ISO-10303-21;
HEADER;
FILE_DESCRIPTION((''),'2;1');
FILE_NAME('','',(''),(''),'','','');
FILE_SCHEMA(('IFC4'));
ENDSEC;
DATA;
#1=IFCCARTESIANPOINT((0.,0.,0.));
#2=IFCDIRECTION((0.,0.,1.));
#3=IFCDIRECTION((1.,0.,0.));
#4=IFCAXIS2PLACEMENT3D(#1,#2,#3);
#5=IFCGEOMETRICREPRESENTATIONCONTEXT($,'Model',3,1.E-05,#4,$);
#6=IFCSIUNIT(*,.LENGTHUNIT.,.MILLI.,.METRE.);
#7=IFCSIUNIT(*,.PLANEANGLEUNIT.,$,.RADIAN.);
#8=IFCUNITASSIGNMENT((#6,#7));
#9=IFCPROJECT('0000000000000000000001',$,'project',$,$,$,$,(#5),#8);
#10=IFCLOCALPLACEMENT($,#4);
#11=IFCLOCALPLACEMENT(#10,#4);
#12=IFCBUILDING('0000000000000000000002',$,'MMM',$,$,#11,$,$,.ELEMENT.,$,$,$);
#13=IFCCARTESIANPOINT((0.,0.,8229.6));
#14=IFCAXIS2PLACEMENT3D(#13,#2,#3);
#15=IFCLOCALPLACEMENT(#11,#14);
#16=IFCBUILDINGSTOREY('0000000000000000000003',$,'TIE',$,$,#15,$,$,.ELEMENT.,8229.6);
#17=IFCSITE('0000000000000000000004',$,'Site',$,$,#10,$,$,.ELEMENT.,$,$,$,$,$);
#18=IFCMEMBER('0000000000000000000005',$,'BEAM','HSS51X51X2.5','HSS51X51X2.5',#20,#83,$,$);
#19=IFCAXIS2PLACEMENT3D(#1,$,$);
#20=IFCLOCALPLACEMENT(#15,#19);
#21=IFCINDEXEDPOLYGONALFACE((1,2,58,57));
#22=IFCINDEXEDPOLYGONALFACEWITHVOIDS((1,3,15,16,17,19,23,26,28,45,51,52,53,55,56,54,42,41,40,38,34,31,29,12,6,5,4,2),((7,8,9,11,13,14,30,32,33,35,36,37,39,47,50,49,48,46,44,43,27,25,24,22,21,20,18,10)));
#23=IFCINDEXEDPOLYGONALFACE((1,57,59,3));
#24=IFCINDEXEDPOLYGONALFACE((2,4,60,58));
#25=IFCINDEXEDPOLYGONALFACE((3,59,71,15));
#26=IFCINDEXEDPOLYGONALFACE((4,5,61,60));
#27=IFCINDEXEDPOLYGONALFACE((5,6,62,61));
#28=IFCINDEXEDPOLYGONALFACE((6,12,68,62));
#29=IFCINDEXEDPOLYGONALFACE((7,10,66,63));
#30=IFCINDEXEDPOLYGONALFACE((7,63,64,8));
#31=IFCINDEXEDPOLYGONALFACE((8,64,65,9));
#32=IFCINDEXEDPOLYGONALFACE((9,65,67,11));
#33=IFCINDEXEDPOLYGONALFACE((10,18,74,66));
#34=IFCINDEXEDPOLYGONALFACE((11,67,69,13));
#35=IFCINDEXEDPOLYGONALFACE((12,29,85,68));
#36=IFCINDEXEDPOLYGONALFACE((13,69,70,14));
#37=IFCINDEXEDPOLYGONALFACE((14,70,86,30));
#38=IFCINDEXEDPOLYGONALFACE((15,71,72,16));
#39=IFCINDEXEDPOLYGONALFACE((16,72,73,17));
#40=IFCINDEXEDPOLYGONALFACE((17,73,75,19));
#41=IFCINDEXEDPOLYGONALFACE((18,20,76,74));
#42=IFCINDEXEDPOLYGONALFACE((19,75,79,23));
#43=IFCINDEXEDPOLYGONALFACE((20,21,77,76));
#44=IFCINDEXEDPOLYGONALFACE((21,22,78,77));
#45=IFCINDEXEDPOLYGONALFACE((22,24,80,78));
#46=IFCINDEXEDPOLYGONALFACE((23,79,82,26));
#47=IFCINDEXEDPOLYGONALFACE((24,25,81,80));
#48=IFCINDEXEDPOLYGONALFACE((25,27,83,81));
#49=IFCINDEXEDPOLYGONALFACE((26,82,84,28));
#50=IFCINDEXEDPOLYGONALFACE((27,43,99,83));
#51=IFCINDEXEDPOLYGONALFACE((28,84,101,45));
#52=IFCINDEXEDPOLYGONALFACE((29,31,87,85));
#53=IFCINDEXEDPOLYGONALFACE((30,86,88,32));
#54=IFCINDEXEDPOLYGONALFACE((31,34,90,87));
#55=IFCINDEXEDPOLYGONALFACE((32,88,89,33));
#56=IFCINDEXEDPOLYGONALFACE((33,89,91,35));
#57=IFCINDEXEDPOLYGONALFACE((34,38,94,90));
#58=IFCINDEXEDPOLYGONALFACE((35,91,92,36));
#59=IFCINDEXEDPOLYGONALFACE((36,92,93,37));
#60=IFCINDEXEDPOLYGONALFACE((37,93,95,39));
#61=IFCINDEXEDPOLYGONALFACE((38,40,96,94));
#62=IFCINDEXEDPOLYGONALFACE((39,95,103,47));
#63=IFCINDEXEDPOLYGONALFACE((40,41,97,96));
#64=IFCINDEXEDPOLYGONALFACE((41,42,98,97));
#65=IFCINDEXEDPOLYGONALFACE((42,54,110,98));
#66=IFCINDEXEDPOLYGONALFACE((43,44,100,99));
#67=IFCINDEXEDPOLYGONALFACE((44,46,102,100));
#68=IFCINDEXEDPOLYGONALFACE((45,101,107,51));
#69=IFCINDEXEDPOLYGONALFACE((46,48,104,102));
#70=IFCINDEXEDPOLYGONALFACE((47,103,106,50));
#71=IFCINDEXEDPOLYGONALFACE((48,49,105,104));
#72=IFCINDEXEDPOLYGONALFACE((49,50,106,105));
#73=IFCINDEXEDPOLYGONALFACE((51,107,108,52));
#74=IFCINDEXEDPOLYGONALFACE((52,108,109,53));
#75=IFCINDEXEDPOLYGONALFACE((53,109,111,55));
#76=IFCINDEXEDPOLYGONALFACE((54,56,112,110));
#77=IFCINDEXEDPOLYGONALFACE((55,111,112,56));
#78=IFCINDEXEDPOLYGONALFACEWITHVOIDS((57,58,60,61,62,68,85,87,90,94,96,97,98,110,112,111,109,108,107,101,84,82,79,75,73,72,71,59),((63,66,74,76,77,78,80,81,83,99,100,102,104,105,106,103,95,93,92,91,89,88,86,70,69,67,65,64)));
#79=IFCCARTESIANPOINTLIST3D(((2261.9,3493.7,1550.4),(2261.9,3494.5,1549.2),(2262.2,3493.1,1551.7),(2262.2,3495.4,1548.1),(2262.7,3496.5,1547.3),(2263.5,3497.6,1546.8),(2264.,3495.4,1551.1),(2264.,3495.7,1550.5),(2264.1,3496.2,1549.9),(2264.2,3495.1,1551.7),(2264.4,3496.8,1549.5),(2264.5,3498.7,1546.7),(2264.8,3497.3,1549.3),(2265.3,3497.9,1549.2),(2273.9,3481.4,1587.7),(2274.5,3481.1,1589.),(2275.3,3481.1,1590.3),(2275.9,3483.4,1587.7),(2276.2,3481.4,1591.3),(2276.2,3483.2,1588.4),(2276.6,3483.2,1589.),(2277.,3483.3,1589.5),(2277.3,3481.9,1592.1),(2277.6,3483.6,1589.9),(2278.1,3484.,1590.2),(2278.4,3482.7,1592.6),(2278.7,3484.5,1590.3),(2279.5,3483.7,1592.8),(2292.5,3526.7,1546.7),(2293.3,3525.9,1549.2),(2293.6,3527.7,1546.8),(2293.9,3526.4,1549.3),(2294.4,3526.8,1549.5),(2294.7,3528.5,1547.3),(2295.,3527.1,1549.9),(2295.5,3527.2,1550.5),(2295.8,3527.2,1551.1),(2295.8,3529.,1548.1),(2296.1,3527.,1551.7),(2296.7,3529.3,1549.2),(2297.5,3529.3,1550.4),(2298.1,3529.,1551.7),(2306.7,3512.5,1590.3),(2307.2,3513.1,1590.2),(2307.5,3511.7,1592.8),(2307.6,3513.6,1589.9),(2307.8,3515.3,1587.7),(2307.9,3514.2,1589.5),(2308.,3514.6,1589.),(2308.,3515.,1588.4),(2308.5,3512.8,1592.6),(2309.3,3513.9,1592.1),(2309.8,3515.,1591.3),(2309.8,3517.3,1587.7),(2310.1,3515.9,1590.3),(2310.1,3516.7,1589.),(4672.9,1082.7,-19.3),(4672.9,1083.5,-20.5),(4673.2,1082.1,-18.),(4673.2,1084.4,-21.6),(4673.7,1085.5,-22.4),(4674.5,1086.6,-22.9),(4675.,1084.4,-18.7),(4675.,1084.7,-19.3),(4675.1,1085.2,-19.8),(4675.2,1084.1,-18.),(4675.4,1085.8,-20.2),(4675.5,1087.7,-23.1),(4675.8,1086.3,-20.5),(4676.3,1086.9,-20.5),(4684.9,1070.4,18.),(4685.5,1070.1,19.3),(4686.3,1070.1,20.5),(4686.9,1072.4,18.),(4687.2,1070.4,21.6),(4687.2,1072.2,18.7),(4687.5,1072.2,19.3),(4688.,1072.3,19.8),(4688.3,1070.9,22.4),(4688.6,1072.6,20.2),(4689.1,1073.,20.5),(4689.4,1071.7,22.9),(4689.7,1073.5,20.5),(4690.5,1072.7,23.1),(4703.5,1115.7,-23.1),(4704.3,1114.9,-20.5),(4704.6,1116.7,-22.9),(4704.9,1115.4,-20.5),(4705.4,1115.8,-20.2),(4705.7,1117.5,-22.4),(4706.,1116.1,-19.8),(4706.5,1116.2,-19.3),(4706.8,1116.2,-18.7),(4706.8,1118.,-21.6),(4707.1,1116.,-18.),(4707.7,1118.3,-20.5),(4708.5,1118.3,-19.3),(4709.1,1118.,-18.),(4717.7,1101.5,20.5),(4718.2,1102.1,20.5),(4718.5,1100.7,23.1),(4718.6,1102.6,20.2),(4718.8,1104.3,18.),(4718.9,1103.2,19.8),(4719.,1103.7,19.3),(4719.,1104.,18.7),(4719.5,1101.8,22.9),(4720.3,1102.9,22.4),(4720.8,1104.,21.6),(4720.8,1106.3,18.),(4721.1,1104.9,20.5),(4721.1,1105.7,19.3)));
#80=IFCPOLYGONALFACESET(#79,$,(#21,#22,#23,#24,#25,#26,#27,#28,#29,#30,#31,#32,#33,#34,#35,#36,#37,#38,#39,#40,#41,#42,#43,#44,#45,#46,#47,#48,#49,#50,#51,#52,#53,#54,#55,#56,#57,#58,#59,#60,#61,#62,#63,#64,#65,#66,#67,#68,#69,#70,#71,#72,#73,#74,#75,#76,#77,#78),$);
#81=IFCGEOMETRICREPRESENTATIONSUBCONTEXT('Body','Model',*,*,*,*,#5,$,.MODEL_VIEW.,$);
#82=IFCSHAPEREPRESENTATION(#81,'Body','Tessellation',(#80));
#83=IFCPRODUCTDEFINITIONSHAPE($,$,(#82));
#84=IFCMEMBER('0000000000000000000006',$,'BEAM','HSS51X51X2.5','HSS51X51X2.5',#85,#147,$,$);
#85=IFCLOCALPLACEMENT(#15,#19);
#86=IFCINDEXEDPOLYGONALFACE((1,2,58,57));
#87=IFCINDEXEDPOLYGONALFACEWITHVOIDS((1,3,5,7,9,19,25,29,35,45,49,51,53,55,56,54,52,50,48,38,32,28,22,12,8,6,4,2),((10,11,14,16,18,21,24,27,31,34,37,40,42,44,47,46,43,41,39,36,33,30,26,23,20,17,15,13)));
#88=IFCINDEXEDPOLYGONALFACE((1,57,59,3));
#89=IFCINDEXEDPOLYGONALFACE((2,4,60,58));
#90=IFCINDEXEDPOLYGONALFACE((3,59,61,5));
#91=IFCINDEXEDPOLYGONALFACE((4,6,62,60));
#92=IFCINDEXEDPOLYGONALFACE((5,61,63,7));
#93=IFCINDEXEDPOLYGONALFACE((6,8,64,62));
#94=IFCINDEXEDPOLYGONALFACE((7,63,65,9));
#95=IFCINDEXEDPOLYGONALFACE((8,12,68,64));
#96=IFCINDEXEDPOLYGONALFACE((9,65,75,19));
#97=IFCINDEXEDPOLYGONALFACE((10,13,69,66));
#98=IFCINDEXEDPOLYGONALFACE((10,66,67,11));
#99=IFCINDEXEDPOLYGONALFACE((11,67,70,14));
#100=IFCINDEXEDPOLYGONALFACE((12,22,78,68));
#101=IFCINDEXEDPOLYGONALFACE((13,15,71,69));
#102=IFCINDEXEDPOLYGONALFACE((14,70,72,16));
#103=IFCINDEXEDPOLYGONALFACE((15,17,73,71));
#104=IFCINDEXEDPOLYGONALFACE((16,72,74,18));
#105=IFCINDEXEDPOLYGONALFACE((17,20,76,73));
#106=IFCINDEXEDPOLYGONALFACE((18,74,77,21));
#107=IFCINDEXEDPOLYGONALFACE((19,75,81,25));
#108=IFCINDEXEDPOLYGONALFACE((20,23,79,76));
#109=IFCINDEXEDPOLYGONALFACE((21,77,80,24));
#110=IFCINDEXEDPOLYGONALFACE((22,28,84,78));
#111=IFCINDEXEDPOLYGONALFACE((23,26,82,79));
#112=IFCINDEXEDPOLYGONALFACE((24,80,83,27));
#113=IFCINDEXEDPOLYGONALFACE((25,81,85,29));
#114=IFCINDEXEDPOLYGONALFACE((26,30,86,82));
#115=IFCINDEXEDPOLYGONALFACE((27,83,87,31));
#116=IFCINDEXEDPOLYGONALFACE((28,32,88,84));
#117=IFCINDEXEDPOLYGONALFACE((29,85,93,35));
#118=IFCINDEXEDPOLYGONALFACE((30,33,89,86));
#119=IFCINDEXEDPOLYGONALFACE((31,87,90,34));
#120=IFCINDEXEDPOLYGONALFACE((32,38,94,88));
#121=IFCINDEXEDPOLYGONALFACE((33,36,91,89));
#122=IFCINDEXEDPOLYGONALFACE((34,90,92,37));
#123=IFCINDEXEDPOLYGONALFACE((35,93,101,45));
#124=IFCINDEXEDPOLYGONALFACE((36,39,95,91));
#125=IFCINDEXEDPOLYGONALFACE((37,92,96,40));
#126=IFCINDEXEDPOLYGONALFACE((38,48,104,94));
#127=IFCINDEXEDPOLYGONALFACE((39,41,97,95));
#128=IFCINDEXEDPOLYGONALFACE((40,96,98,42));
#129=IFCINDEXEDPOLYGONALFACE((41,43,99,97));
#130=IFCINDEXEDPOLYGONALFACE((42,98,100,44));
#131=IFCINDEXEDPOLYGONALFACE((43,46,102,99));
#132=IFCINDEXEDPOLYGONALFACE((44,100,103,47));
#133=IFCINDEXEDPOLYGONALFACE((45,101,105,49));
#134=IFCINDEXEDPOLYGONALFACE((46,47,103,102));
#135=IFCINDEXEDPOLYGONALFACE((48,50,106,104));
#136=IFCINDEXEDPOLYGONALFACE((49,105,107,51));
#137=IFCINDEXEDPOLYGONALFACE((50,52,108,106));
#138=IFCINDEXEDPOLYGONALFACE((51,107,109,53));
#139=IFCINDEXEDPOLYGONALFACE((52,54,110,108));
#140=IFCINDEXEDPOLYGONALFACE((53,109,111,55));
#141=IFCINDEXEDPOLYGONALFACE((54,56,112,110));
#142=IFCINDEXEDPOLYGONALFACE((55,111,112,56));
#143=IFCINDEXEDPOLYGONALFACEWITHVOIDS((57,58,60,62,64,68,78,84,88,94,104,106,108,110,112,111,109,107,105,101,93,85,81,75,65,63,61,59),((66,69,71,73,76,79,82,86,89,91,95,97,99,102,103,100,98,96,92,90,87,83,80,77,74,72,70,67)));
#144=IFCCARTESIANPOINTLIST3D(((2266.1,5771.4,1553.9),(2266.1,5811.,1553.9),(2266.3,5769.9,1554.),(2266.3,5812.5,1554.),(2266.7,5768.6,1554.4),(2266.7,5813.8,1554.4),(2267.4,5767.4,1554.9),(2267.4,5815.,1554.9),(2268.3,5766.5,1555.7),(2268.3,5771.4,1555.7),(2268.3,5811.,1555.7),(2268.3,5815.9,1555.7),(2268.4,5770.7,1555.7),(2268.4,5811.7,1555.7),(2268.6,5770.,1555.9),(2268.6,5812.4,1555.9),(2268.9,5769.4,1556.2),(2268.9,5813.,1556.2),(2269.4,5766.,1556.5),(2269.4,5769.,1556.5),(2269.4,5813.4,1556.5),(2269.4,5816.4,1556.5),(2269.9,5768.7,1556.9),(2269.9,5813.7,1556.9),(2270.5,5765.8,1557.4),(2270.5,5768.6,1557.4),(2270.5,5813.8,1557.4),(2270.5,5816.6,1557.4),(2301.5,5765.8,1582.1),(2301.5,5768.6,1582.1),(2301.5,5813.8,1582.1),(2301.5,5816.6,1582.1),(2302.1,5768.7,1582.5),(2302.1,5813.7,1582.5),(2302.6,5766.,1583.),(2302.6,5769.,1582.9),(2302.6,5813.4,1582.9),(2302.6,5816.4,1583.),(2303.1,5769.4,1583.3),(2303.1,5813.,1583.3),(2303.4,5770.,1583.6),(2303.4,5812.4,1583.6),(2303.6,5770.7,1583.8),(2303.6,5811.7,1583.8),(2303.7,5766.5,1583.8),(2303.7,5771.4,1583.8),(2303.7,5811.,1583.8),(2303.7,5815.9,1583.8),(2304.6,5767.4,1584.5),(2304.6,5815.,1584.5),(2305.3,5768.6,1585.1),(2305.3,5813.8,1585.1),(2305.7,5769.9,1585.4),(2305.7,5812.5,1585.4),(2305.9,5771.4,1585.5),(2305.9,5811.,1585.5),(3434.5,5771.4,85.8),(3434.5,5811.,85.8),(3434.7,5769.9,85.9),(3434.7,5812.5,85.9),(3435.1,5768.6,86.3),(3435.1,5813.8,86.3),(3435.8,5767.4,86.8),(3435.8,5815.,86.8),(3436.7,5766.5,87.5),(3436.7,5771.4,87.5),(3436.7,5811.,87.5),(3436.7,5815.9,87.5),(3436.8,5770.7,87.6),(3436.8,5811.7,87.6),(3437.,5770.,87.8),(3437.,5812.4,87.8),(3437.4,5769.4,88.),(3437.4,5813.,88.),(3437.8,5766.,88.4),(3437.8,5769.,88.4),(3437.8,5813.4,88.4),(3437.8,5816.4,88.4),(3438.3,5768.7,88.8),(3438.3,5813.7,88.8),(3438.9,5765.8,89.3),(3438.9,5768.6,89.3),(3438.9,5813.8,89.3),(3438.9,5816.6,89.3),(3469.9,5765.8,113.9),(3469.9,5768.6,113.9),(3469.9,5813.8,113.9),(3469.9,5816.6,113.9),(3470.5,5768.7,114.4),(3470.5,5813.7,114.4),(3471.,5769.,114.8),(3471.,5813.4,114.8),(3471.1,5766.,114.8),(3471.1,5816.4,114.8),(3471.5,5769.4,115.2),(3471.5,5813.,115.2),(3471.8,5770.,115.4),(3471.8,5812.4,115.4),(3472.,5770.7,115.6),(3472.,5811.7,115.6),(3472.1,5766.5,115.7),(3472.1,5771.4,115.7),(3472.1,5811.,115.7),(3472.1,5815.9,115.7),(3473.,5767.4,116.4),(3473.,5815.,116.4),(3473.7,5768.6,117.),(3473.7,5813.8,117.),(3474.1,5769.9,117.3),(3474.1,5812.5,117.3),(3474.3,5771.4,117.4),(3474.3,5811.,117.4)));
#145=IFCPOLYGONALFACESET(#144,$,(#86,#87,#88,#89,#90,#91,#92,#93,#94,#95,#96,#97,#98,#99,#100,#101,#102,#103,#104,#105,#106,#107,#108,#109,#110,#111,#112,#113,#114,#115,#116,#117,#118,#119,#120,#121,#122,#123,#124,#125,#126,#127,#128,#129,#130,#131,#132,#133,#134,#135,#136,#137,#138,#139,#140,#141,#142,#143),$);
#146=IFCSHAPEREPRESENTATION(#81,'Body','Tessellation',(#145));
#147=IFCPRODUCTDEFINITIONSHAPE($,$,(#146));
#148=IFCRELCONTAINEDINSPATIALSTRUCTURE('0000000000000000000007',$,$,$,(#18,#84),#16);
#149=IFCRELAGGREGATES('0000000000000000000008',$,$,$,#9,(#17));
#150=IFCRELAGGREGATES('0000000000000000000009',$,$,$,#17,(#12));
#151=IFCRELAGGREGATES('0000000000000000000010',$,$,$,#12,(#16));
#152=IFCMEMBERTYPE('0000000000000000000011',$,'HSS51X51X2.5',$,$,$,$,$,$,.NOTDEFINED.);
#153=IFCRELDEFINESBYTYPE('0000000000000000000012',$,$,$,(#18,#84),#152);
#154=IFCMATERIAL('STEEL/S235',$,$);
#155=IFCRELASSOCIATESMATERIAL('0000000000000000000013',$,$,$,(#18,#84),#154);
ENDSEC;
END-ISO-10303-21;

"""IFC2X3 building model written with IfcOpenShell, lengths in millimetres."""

from ifc_helpers import new_model, si_unit, frame, origin_with_axes, origin_2d_with_axis, place, context, subcontext, project, spatial, hollow_rectangle, extrude, material, type_object, element, save


model = new_model("IFC2X3")

# Units and contexts
model_context = context("Model", 3, precision=1e-05, world=origin_with_axes())
body_context = subcontext(model_context, "Body", "Model", "MODEL_VIEW")
ifc_project = project(units=[si_unit("LENGTHUNIT", "METRE", prefix="MILLI"), si_unit("PLANEANGLEUNIT", "RADIAN")], contexts=[model_context])

# Site, building, storey
site_placement = place(None, origin_with_axes())
site = spatial("IfcSite", under=ifc_project, at=site_placement, Name="Site", CompositionType="ELEMENT")
building_placement = place(site_placement, origin_with_axes())
building = spatial("IfcBuilding", under=site, at=building_placement, Name="MMM", CompositionType="ELEMENT")
storey_placement = place(building_placement, frame((0.0, 0.0, 8229.6), z_axis=(0.0, 0.0, 1.0), x_axis=(1.0, 0.0, 0.0)))
storey = spatial("IfcBuildingStorey", under=building, at=storey_placement, Name="TIE", CompositionType="ELEMENT", Elevation=8229.6)

# Shared definitions
ifc_material = material(Name="STEEL/S235")

# Members
member_type_1 = type_object("IfcMemberType", Name="HSS51X51X2.5", PredefinedType="NOTDEFINED")
member_1_placement = place(storey_placement, frame((2286.0, 3505.2, 1569.7), z_axis=(0.295704, -0.295704, 0.90836), x_axis=(0.642308, -0.642308, -0.418188)))
element("IfcMember", 1, at=member_1_placement, inside=storey, type_object=member_type_1, material=ifc_material, Name="BEAM", Description="HSS51X51X2.5", ObjectType="HSS51X51X2.5", context=body_context, shape_type="SweptSolid", body=[
    extrude(hollow_rectangle(XDim=50.8, YDim=50.8, WallThickness=2.8, InnerFilletRadius=2.8, OuterFilletRadius=5.6, at=origin_2d_with_axis()), frame((3753.7, 0.0, 0.0), z_axis=(-1.0, 0.0, 0.0), x_axis=(0.0, -1.0, 0.0)), (0.0, 0.0, 1.0), 3753.7),
])
for number, where, z_axis, x_axis, name in (
    (2, (3454.4, 5791.2, 101.6), (0.782448, 0.0, 0.622716), (-0.622716, 0.0, 0.782448), "BEAM"),
):
    element("IfcMember", number, at=place(storey_placement, frame(where, z_axis=z_axis, x_axis=x_axis)), inside=storey, type_object=member_type_1, material=ifc_material, Name=name, Description="HSS51X51X2.5", ObjectType="HSS51X51X2.5", context=body_context, shape_type="SweptSolid", body=[
        extrude(hollow_rectangle(XDim=50.8, YDim=50.8, WallThickness=2.8, InnerFilletRadius=2.8, OuterFilletRadius=5.6, at=origin_2d_with_axis()), frame((1876.3, 0.0, 0.0), z_axis=(-1.0, 0.0, 0.0), x_axis=(0.0, -1.0, 0.0)), (0.0, 0.0, 1.0), 1876.3),
    ])

save(model, "model.ifc")
